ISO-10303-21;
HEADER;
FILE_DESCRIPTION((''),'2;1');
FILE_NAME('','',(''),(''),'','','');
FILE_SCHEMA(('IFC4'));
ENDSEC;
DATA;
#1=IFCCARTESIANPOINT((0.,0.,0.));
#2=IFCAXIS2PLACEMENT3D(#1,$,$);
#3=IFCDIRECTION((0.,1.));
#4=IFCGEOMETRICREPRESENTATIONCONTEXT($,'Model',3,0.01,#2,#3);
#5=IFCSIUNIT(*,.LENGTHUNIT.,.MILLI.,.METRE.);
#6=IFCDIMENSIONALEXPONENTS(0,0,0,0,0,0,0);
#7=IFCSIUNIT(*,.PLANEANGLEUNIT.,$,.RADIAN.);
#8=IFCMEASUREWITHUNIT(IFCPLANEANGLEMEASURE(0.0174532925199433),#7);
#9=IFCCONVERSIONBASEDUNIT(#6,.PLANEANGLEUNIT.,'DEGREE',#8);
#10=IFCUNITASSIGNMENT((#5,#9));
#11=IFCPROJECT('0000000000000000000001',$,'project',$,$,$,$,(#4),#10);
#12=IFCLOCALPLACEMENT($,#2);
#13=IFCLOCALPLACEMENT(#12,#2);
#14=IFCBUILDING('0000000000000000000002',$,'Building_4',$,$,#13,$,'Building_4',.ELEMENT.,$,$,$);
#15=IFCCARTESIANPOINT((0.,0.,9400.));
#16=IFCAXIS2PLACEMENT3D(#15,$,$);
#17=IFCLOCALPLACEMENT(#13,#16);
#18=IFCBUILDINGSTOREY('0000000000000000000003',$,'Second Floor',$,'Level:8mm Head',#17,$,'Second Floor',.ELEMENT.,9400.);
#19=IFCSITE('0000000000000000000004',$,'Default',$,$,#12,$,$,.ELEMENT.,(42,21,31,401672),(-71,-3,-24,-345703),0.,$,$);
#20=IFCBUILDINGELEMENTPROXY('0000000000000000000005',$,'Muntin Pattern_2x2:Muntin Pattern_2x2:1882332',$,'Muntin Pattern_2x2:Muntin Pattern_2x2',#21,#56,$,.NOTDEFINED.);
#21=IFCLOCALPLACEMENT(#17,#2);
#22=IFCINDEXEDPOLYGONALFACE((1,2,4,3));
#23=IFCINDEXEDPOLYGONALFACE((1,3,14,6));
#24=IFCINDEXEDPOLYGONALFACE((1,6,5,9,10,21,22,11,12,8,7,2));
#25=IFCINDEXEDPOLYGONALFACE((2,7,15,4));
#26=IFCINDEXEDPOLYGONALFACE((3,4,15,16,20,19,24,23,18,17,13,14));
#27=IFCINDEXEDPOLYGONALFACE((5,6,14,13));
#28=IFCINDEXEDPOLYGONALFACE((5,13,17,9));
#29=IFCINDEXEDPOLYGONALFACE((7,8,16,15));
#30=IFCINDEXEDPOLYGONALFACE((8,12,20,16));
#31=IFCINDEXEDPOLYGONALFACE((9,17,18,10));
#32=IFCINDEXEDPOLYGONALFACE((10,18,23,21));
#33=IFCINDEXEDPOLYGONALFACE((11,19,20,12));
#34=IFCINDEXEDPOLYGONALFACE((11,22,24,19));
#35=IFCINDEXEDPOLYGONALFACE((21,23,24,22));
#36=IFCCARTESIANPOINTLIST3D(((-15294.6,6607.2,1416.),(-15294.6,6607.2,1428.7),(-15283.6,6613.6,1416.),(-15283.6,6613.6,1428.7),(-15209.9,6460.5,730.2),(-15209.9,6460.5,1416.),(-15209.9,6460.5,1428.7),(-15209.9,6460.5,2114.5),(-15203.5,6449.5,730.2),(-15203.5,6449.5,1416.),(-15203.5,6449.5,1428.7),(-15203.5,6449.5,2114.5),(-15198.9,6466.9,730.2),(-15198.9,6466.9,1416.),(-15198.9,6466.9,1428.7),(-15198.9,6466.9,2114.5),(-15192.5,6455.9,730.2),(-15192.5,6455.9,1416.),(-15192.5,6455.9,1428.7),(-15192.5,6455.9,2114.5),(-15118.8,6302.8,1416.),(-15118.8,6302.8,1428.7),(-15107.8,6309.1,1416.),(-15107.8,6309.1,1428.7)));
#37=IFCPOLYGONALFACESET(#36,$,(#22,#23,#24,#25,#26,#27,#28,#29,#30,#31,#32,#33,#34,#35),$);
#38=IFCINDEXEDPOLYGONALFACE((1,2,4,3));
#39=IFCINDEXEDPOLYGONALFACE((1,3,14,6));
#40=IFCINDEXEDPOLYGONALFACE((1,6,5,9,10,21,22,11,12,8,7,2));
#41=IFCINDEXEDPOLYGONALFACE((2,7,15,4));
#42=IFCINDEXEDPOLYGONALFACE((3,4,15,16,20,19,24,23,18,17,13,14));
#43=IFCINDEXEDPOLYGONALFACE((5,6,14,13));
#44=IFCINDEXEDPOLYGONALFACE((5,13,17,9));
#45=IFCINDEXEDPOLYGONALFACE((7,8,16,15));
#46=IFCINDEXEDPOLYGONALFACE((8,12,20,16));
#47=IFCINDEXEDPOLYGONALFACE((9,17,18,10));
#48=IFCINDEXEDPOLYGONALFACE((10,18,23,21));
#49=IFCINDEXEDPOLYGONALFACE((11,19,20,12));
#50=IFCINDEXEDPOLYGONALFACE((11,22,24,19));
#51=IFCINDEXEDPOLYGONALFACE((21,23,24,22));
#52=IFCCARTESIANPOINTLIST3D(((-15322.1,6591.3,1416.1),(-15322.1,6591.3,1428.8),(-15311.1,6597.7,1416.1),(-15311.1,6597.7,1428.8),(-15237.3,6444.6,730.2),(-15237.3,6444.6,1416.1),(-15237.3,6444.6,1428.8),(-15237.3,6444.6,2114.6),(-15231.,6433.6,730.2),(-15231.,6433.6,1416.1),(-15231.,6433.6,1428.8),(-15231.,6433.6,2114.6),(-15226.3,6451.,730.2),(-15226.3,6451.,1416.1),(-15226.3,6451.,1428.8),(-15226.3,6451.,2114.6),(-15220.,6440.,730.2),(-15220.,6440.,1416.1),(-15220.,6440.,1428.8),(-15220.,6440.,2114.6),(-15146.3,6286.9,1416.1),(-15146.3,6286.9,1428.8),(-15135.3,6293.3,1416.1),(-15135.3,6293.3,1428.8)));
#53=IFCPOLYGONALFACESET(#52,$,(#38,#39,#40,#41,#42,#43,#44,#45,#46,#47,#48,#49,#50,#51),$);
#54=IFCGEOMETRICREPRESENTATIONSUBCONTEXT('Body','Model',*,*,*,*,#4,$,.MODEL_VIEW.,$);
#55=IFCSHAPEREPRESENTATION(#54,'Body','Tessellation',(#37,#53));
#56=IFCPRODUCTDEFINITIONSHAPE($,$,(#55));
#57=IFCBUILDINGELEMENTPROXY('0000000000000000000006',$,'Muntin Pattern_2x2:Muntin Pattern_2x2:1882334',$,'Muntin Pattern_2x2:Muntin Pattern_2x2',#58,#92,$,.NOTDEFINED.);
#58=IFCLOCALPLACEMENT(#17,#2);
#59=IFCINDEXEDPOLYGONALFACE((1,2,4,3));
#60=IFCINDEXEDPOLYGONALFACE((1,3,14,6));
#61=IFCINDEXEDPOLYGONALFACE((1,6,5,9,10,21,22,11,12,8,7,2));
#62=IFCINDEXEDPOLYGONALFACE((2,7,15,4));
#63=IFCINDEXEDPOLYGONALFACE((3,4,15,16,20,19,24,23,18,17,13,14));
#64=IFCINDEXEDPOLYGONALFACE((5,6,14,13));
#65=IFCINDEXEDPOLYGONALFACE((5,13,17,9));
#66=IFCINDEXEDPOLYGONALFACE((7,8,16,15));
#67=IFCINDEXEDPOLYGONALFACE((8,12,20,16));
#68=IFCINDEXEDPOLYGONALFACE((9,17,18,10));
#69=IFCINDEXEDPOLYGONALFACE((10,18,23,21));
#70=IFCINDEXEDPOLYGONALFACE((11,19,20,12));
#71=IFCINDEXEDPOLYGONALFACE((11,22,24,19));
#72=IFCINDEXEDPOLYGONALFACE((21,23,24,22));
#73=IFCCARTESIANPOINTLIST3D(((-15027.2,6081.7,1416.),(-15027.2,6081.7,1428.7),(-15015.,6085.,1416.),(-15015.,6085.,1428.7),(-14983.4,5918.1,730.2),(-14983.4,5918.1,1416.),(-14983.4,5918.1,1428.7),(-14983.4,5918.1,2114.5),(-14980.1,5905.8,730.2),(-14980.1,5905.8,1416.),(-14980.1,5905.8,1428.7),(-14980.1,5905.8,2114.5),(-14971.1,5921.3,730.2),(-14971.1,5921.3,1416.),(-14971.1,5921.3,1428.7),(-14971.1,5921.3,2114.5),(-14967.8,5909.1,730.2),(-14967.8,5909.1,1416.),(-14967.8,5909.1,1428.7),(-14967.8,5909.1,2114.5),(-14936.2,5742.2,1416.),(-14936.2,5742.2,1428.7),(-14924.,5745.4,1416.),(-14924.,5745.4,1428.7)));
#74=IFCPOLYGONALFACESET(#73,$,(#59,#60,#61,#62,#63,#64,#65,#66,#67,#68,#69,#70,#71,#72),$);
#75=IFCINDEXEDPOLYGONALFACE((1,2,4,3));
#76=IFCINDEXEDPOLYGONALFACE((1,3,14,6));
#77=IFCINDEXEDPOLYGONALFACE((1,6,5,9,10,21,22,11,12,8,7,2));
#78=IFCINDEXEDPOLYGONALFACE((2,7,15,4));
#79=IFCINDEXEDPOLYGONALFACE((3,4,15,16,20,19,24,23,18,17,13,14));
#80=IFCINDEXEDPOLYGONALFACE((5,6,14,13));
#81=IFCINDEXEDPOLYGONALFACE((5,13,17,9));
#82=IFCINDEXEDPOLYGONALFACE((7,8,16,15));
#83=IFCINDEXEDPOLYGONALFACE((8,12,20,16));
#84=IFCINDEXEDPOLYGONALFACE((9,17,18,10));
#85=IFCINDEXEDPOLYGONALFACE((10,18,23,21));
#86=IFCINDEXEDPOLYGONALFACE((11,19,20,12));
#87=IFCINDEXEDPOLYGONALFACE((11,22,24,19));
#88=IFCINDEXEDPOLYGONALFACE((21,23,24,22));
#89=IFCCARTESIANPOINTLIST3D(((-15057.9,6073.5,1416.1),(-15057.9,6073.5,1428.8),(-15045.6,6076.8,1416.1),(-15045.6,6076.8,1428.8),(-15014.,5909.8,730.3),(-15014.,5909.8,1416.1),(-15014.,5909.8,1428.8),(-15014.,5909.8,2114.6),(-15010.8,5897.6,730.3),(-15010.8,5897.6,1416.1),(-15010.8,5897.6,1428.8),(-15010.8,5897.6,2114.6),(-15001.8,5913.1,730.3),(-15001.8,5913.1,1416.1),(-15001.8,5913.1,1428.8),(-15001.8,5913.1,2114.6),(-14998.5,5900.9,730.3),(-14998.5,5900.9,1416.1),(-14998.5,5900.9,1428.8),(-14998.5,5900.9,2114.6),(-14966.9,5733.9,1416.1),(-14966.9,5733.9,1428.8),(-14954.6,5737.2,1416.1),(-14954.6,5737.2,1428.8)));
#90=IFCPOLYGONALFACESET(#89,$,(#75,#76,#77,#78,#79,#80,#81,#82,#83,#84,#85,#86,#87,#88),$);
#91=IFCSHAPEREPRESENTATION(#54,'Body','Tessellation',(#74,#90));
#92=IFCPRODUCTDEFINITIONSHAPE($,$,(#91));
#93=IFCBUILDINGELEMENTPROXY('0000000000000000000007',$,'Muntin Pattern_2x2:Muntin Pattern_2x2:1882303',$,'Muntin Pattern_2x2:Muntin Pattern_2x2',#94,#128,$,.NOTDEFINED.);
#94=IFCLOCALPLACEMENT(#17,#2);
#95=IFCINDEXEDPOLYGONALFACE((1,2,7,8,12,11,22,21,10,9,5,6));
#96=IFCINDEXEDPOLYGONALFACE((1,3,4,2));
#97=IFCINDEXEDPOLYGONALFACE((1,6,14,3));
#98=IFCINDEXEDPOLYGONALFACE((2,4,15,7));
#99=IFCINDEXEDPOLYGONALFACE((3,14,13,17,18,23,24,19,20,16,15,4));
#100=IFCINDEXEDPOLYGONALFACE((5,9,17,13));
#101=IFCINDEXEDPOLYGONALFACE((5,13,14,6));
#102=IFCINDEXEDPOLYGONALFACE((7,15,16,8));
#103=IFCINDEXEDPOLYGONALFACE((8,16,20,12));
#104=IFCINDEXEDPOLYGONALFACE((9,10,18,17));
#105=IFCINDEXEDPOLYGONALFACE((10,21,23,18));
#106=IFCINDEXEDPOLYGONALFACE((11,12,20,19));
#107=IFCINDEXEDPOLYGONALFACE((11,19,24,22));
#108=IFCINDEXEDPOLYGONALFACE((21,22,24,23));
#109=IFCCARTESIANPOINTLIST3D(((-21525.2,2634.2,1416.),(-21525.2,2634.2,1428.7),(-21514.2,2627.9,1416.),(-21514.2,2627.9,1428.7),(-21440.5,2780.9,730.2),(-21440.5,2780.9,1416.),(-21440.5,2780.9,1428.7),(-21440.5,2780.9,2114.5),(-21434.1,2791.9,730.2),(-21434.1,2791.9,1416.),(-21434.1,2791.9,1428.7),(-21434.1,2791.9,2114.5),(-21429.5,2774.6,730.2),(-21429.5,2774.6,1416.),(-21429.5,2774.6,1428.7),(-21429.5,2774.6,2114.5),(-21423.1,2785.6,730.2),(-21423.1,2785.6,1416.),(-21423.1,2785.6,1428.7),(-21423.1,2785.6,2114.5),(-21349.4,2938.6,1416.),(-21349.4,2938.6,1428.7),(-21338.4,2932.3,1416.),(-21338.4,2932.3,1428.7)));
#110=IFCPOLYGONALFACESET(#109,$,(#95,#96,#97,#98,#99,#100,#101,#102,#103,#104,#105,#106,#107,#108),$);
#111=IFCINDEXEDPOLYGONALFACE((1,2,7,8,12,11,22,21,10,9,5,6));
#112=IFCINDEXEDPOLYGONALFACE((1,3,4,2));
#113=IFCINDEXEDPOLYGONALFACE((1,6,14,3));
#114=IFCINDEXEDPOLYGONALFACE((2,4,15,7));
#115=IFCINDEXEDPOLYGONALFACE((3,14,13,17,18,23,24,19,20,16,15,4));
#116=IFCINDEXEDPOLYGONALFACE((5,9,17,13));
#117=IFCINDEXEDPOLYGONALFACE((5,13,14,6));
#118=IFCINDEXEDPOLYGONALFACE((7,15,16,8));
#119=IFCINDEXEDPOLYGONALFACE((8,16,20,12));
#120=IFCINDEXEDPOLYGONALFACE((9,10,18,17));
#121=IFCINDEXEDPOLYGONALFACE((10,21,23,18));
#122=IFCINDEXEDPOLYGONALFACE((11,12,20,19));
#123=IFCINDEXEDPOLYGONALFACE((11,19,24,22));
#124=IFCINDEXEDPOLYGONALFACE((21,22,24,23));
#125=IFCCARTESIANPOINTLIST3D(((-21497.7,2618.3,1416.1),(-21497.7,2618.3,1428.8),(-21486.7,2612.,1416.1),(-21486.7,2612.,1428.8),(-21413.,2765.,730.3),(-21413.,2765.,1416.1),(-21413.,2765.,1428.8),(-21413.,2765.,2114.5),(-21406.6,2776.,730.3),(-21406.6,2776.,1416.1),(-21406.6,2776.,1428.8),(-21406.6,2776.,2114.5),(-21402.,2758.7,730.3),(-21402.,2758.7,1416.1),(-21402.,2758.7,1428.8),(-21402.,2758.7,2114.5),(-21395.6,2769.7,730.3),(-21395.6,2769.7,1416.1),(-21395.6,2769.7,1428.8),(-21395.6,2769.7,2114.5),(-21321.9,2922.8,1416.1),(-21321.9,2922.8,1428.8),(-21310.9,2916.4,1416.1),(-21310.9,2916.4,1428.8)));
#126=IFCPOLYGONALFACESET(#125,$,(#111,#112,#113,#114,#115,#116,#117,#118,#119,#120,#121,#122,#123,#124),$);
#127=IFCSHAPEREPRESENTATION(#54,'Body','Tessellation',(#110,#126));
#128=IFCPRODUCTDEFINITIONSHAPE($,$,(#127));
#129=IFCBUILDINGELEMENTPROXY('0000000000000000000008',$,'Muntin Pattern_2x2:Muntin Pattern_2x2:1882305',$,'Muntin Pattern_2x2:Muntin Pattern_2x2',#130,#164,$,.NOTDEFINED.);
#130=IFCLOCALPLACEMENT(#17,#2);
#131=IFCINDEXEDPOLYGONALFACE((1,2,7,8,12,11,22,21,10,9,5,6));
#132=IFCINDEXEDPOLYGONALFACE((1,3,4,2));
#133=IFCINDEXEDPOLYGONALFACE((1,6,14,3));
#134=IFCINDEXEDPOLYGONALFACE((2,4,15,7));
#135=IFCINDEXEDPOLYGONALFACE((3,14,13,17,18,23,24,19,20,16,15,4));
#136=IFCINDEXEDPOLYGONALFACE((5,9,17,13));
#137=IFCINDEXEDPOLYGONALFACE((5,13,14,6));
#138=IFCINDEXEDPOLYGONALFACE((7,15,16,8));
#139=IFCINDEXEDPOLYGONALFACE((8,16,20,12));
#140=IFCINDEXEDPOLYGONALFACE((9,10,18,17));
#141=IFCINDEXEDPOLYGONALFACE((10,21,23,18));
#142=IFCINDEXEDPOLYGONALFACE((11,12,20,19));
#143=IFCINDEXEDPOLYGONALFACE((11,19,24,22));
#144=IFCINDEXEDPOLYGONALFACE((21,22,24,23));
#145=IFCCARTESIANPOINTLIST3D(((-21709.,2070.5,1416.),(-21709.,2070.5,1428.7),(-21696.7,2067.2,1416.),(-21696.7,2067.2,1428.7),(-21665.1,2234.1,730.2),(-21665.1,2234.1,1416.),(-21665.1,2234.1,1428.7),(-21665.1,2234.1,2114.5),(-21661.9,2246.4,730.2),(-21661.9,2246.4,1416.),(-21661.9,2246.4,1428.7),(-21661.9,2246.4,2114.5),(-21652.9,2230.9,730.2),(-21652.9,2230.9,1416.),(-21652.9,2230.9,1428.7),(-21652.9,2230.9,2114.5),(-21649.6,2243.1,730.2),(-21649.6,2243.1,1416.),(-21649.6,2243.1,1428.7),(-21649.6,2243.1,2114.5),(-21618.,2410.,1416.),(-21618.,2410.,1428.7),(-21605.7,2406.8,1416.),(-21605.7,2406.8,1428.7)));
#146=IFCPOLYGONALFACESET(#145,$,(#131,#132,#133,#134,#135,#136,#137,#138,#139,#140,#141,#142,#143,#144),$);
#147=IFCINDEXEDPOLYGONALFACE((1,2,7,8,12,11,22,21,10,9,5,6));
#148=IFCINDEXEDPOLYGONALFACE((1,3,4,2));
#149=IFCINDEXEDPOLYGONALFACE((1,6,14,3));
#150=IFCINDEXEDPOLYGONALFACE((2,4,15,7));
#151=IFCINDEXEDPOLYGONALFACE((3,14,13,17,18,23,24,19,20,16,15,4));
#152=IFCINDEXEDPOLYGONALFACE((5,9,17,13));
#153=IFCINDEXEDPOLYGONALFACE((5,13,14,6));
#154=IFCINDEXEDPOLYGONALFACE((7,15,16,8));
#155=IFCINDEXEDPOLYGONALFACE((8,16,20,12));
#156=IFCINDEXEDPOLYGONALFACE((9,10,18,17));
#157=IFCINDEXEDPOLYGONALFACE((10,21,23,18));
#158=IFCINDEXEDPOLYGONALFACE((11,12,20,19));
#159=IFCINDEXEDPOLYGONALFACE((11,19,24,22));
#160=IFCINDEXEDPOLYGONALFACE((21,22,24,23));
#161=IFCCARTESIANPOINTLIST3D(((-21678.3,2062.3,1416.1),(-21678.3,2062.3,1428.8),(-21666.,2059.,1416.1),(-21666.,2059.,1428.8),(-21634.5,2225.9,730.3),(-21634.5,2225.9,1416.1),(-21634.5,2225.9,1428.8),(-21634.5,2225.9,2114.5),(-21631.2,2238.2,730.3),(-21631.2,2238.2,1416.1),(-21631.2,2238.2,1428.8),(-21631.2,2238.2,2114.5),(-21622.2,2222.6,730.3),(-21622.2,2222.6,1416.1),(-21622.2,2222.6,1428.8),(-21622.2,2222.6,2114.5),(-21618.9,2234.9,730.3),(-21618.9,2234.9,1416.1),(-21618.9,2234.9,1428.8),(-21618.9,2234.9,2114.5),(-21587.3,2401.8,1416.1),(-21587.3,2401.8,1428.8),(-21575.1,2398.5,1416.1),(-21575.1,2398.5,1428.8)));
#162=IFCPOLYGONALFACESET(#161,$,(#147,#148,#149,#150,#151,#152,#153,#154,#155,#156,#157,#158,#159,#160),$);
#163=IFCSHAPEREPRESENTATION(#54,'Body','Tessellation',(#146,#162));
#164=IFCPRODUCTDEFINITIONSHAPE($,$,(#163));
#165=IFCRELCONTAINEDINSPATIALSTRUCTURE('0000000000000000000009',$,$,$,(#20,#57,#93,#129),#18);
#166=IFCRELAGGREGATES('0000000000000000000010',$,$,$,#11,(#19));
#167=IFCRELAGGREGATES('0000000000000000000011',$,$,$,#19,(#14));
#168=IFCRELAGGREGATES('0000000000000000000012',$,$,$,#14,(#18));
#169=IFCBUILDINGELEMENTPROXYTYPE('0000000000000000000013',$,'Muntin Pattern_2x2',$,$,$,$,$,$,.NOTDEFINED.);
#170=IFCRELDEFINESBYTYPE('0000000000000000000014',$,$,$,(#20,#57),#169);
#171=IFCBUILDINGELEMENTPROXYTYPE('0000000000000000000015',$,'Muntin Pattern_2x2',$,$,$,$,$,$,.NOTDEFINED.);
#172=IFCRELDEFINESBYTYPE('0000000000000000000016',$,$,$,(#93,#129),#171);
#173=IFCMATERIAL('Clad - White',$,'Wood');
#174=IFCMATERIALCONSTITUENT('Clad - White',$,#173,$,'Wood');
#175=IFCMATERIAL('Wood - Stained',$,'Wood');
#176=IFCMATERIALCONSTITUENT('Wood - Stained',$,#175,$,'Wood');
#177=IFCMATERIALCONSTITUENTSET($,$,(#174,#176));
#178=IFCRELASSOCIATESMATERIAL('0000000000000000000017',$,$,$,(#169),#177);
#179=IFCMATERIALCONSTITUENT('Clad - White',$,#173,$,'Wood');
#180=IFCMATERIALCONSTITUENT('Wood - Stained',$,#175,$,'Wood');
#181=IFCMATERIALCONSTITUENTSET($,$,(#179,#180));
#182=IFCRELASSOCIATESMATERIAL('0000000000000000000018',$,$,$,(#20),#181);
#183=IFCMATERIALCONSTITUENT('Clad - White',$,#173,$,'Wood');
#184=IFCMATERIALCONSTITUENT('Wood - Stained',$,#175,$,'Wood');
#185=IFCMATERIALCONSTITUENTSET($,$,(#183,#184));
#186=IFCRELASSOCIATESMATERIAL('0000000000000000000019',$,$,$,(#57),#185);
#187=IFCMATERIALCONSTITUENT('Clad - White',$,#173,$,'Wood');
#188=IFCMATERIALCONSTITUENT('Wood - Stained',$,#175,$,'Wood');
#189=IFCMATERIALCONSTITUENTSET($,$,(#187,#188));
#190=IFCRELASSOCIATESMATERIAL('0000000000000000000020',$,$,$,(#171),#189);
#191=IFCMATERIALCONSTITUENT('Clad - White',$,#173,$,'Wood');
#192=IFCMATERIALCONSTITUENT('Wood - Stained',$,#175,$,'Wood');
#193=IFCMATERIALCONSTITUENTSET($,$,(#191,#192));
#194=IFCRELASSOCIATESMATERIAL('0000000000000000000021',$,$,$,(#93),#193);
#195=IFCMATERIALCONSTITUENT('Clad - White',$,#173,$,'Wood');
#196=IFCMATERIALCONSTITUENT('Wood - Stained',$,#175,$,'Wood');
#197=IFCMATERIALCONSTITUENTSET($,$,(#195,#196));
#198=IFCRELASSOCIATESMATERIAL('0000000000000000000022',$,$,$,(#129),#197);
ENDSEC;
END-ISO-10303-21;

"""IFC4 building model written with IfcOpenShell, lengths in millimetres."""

from ifc_helpers import new_model, entity, si_unit, converted_unit, direction, frame, origin, place, context, subcontext, project, spatial, indexed_curve, outline, extrude, source, transform, mapped, material, constituent, constituent_set, type_object, type_shapes, element, save


model = new_model("IFC4")

# Units and contexts
model_context = context("Model", 3, precision=0.01, world=origin(), true_north=direction((0.0, 1.0)))
body_context = subcontext(model_context, "Body", "Model", "MODEL_VIEW")
ifc_project = project(units=[si_unit("LENGTHUNIT", "METRE", prefix="MILLI"), converted_unit("PLANEANGLEUNIT", "DEGREE", entity("IfcPlaneAngleMeasure", 0.0174532925199433), si_unit("PLANEANGLEUNIT", "RADIAN"), dimensions=[0, 0, 0, 0, 0, 0, 0])], contexts=[model_context])

# Site, building, storey
site_placement = place(None, origin())
site = spatial("IfcSite", under=ifc_project, at=site_placement, Name="Default", CompositionType="ELEMENT", RefLatitude=(42, 21, 31, 401672), RefLongitude=(-71, -3, -24, -345703), RefElevation=0.0)
building_placement = place(site_placement, origin())
building = spatial("IfcBuilding", under=site, at=building_placement, Name="Building_4", LongName="Building_4", CompositionType="ELEMENT")
storey_placement = place(building_placement, frame((0.0, 0.0, 9400.0)))
storey = spatial("IfcBuildingStorey", under=building, at=storey_placement, Name="Second Floor", ObjectType="Level:8mm Head", LongName="Second Floor", CompositionType="ELEMENT", Elevation=9400.0)

# Building element proxies
ifc_material_1 = material(Name="Clad - White", Category="Wood")
ifc_material_2 = material(Name="Wood - Stained", Category="Wood")
ifc_constituent_1 = constituent(ifc_material_1, Name="Clad - White", Category="Wood")
ifc_constituent_2 = constituent(ifc_material_2, Name="Wood - Stained", Category="Wood")
ifc_constituent_set_1 = constituent_set(constituents=[ifc_constituent_1, ifc_constituent_2])
building_element_proxy_type_1 = type_object("IfcBuildingElementProxyType", Name="Muntin Pattern_2x2", PredefinedType="NOTDEFINED", material=ifc_constituent_set_1)
shared_shape_1 = source(origin(), body_context, "Body", "SweptSolid", [
    extrude(outline(indexed_curve([(6.4, -6.4), (692.1, -6.4), (692.1, 6.3), (6.4, 6.3), (6.4, 175.8), (-6.3, 175.8), (-6.3, 6.3), (-692.2, 6.3), (-692.2, -6.4), (-6.3, -6.4), (-6.3, -175.8), (6.4, -175.8), (6.4, -6.4)], self_intersect=False)), frame((0.0, 9.5, 692.1), z_axis=(0.0, 1.0, 0.0), x_axis=(0.0, 0.0, 1.0)), (0.0, 0.0, 1.0), 12.7),
    extrude(outline(indexed_curve([(6.4, -6.4), (692.1, -6.4), (692.1, 6.3), (6.4, 6.3), (6.4, 175.8), (-6.3, 175.8), (-6.3, 6.3), (-692.2, 6.3), (-692.2, -6.4), (-6.3, -6.4), (-6.3, -175.8), (6.4, -175.8), (6.4, -6.4)], self_intersect=False)), frame((0.0, -22.2, 692.2), z_axis=(0.0, 1.0, 0.0), x_axis=(0.0, 0.0, 1.0)), (0.0, 0.0, 1.0), 12.7),
])
type_shapes(building_element_proxy_type_1, [shared_shape_1])
ifc_constituent_3 = constituent(ifc_material_1, Name="Clad - White", Category="Wood")
ifc_constituent_4 = constituent(ifc_material_2, Name="Wood - Stained", Category="Wood")
ifc_constituent_set_2 = constituent_set(constituents=[ifc_constituent_3, ifc_constituent_4])
proxy_1_placement = place(storey_placement, frame((-15214.9, 6450.2, 730.2), z_axis=(0.0, 0.0, 1.0), x_axis=(0.5, -0.866025, 0.0)))
element("IfcBuildingElementProxy", 1, at=proxy_1_placement, inside=storey, type_object=building_element_proxy_type_1, material=ifc_constituent_set_2, Name="Muntin Pattern_2x2:Muntin Pattern_2x2:1882332", ObjectType="Muntin Pattern_2x2:Muntin Pattern_2x2", PredefinedType="NOTDEFINED", context=body_context, shape_type="MappedRepresentation", body=[
    mapped(shared_shape_1, transform((0.0, 0.0, 0.0), scale=1.0)),
])
ifc_constituent_5 = constituent(ifc_material_1, Name="Clad - White", Category="Wood")
ifc_constituent_6 = constituent(ifc_material_2, Name="Wood - Stained", Category="Wood")
ifc_constituent_set_3 = constituent_set(constituents=[ifc_constituent_5, ifc_constituent_6])
proxy_2_placement = place(storey_placement, frame((-14990.9, 5909.5, 730.3), z_axis=(0.0, 0.0, 1.0), x_axis=(0.258819, -0.965926, 0.0)))
element("IfcBuildingElementProxy", 2, at=proxy_2_placement, inside=storey, type_object=building_element_proxy_type_1, material=ifc_constituent_set_3, Name="Muntin Pattern_2x2:Muntin Pattern_2x2:1882334", ObjectType="Muntin Pattern_2x2:Muntin Pattern_2x2", PredefinedType="NOTDEFINED", context=body_context, shape_type="MappedRepresentation", body=[
    mapped(shared_shape_1, transform((0.0, 0.0, 0.0), scale=1.0)),
])
ifc_constituent_7 = constituent(ifc_material_1, Name="Clad - White", Category="Wood")
ifc_constituent_8 = constituent(ifc_material_2, Name="Wood - Stained", Category="Wood")
ifc_constituent_set_4 = constituent_set(constituents=[ifc_constituent_7, ifc_constituent_8])
ifc_constituent_9 = constituent(ifc_material_1, Name="Clad - White", Category="Wood")
ifc_constituent_10 = constituent(ifc_material_2, Name="Wood - Stained", Category="Wood")
ifc_constituent_set_5 = constituent_set(constituents=[ifc_constituent_9, ifc_constituent_10])
building_element_proxy_type_2 = type_object("IfcBuildingElementProxyType", Name="Muntin Pattern_2x2", PredefinedType="NOTDEFINED", material=ifc_constituent_set_5)
shared_shape_2 = source(origin(), body_context, "Body", "SweptSolid", [
    extrude(outline(indexed_curve([(6.4, -6.4), (692.1, -6.4), (692.1, 6.3), (6.4, 6.3), (6.4, 175.8), (-6.3, 175.8), (-6.3, 6.3), (-692.2, 6.3), (-692.2, -6.4), (-6.3, -6.4), (-6.3, -175.8), (6.4, -175.8), (6.4, -6.4)], self_intersect=False)), frame((0.0, -22.2, 692.1), z_axis=(0.0, 1.0, 0.0), x_axis=(0.0, 0.0, 1.0)), (0.0, 0.0, 1.0), 12.7),
    extrude(outline(indexed_curve([(6.4, -6.4), (692.1, -6.4), (692.1, 6.3), (6.4, 6.3), (6.4, 175.8), (-6.3, 175.8), (-6.3, 6.3), (-692.1, 6.3), (-692.1, -6.4), (-6.3, -6.4), (-6.3, -175.8), (6.4, -175.8), (6.4, -6.4)], self_intersect=False)), frame((0.0, 9.5, 692.1), z_axis=(0.0, 1.0, 0.0), x_axis=(0.0, 0.0, 1.0)), (0.0, 0.0, 1.0), 12.7),
])
type_shapes(building_element_proxy_type_2, [shared_shape_2])
proxy_3_placement = place(storey_placement, frame((-21418.0, 2775.3, 730.3), z_axis=(0.0, 0.0, 1.0), x_axis=(-0.5, -0.866025, 0.0)))
element("IfcBuildingElementProxy", 3, at=proxy_3_placement, inside=storey, type_object=building_element_proxy_type_2, material=ifc_constituent_set_4, Name="Muntin Pattern_2x2:Muntin Pattern_2x2:1882303", ObjectType="Muntin Pattern_2x2:Muntin Pattern_2x2", PredefinedType="NOTDEFINED", context=body_context, shape_type="MappedRepresentation", body=[
    mapped(shared_shape_2, transform((0.0, 0.0, 0.0), scale=1.0)),
])
ifc_constituent_11 = constituent(ifc_material_1, Name="Clad - White", Category="Wood")
ifc_constituent_12 = constituent(ifc_material_2, Name="Wood - Stained", Category="Wood")
ifc_constituent_set_6 = constituent_set(constituents=[ifc_constituent_11, ifc_constituent_12])
proxy_4_placement = place(storey_placement, frame((-21642.0, 2234.5, 730.3), z_axis=(0.0, 0.0, 1.0), x_axis=(-0.258819, -0.965926, 0.0)))
element("IfcBuildingElementProxy", 4, at=proxy_4_placement, inside=storey, type_object=building_element_proxy_type_2, material=ifc_constituent_set_6, Name="Muntin Pattern_2x2:Muntin Pattern_2x2:1882305", ObjectType="Muntin Pattern_2x2:Muntin Pattern_2x2", PredefinedType="NOTDEFINED", context=body_context, shape_type="MappedRepresentation", body=[
    mapped(shared_shape_2, transform((0.0, 0.0, 0.0), scale=1.0)),
])

save(model, "model.ifc")
